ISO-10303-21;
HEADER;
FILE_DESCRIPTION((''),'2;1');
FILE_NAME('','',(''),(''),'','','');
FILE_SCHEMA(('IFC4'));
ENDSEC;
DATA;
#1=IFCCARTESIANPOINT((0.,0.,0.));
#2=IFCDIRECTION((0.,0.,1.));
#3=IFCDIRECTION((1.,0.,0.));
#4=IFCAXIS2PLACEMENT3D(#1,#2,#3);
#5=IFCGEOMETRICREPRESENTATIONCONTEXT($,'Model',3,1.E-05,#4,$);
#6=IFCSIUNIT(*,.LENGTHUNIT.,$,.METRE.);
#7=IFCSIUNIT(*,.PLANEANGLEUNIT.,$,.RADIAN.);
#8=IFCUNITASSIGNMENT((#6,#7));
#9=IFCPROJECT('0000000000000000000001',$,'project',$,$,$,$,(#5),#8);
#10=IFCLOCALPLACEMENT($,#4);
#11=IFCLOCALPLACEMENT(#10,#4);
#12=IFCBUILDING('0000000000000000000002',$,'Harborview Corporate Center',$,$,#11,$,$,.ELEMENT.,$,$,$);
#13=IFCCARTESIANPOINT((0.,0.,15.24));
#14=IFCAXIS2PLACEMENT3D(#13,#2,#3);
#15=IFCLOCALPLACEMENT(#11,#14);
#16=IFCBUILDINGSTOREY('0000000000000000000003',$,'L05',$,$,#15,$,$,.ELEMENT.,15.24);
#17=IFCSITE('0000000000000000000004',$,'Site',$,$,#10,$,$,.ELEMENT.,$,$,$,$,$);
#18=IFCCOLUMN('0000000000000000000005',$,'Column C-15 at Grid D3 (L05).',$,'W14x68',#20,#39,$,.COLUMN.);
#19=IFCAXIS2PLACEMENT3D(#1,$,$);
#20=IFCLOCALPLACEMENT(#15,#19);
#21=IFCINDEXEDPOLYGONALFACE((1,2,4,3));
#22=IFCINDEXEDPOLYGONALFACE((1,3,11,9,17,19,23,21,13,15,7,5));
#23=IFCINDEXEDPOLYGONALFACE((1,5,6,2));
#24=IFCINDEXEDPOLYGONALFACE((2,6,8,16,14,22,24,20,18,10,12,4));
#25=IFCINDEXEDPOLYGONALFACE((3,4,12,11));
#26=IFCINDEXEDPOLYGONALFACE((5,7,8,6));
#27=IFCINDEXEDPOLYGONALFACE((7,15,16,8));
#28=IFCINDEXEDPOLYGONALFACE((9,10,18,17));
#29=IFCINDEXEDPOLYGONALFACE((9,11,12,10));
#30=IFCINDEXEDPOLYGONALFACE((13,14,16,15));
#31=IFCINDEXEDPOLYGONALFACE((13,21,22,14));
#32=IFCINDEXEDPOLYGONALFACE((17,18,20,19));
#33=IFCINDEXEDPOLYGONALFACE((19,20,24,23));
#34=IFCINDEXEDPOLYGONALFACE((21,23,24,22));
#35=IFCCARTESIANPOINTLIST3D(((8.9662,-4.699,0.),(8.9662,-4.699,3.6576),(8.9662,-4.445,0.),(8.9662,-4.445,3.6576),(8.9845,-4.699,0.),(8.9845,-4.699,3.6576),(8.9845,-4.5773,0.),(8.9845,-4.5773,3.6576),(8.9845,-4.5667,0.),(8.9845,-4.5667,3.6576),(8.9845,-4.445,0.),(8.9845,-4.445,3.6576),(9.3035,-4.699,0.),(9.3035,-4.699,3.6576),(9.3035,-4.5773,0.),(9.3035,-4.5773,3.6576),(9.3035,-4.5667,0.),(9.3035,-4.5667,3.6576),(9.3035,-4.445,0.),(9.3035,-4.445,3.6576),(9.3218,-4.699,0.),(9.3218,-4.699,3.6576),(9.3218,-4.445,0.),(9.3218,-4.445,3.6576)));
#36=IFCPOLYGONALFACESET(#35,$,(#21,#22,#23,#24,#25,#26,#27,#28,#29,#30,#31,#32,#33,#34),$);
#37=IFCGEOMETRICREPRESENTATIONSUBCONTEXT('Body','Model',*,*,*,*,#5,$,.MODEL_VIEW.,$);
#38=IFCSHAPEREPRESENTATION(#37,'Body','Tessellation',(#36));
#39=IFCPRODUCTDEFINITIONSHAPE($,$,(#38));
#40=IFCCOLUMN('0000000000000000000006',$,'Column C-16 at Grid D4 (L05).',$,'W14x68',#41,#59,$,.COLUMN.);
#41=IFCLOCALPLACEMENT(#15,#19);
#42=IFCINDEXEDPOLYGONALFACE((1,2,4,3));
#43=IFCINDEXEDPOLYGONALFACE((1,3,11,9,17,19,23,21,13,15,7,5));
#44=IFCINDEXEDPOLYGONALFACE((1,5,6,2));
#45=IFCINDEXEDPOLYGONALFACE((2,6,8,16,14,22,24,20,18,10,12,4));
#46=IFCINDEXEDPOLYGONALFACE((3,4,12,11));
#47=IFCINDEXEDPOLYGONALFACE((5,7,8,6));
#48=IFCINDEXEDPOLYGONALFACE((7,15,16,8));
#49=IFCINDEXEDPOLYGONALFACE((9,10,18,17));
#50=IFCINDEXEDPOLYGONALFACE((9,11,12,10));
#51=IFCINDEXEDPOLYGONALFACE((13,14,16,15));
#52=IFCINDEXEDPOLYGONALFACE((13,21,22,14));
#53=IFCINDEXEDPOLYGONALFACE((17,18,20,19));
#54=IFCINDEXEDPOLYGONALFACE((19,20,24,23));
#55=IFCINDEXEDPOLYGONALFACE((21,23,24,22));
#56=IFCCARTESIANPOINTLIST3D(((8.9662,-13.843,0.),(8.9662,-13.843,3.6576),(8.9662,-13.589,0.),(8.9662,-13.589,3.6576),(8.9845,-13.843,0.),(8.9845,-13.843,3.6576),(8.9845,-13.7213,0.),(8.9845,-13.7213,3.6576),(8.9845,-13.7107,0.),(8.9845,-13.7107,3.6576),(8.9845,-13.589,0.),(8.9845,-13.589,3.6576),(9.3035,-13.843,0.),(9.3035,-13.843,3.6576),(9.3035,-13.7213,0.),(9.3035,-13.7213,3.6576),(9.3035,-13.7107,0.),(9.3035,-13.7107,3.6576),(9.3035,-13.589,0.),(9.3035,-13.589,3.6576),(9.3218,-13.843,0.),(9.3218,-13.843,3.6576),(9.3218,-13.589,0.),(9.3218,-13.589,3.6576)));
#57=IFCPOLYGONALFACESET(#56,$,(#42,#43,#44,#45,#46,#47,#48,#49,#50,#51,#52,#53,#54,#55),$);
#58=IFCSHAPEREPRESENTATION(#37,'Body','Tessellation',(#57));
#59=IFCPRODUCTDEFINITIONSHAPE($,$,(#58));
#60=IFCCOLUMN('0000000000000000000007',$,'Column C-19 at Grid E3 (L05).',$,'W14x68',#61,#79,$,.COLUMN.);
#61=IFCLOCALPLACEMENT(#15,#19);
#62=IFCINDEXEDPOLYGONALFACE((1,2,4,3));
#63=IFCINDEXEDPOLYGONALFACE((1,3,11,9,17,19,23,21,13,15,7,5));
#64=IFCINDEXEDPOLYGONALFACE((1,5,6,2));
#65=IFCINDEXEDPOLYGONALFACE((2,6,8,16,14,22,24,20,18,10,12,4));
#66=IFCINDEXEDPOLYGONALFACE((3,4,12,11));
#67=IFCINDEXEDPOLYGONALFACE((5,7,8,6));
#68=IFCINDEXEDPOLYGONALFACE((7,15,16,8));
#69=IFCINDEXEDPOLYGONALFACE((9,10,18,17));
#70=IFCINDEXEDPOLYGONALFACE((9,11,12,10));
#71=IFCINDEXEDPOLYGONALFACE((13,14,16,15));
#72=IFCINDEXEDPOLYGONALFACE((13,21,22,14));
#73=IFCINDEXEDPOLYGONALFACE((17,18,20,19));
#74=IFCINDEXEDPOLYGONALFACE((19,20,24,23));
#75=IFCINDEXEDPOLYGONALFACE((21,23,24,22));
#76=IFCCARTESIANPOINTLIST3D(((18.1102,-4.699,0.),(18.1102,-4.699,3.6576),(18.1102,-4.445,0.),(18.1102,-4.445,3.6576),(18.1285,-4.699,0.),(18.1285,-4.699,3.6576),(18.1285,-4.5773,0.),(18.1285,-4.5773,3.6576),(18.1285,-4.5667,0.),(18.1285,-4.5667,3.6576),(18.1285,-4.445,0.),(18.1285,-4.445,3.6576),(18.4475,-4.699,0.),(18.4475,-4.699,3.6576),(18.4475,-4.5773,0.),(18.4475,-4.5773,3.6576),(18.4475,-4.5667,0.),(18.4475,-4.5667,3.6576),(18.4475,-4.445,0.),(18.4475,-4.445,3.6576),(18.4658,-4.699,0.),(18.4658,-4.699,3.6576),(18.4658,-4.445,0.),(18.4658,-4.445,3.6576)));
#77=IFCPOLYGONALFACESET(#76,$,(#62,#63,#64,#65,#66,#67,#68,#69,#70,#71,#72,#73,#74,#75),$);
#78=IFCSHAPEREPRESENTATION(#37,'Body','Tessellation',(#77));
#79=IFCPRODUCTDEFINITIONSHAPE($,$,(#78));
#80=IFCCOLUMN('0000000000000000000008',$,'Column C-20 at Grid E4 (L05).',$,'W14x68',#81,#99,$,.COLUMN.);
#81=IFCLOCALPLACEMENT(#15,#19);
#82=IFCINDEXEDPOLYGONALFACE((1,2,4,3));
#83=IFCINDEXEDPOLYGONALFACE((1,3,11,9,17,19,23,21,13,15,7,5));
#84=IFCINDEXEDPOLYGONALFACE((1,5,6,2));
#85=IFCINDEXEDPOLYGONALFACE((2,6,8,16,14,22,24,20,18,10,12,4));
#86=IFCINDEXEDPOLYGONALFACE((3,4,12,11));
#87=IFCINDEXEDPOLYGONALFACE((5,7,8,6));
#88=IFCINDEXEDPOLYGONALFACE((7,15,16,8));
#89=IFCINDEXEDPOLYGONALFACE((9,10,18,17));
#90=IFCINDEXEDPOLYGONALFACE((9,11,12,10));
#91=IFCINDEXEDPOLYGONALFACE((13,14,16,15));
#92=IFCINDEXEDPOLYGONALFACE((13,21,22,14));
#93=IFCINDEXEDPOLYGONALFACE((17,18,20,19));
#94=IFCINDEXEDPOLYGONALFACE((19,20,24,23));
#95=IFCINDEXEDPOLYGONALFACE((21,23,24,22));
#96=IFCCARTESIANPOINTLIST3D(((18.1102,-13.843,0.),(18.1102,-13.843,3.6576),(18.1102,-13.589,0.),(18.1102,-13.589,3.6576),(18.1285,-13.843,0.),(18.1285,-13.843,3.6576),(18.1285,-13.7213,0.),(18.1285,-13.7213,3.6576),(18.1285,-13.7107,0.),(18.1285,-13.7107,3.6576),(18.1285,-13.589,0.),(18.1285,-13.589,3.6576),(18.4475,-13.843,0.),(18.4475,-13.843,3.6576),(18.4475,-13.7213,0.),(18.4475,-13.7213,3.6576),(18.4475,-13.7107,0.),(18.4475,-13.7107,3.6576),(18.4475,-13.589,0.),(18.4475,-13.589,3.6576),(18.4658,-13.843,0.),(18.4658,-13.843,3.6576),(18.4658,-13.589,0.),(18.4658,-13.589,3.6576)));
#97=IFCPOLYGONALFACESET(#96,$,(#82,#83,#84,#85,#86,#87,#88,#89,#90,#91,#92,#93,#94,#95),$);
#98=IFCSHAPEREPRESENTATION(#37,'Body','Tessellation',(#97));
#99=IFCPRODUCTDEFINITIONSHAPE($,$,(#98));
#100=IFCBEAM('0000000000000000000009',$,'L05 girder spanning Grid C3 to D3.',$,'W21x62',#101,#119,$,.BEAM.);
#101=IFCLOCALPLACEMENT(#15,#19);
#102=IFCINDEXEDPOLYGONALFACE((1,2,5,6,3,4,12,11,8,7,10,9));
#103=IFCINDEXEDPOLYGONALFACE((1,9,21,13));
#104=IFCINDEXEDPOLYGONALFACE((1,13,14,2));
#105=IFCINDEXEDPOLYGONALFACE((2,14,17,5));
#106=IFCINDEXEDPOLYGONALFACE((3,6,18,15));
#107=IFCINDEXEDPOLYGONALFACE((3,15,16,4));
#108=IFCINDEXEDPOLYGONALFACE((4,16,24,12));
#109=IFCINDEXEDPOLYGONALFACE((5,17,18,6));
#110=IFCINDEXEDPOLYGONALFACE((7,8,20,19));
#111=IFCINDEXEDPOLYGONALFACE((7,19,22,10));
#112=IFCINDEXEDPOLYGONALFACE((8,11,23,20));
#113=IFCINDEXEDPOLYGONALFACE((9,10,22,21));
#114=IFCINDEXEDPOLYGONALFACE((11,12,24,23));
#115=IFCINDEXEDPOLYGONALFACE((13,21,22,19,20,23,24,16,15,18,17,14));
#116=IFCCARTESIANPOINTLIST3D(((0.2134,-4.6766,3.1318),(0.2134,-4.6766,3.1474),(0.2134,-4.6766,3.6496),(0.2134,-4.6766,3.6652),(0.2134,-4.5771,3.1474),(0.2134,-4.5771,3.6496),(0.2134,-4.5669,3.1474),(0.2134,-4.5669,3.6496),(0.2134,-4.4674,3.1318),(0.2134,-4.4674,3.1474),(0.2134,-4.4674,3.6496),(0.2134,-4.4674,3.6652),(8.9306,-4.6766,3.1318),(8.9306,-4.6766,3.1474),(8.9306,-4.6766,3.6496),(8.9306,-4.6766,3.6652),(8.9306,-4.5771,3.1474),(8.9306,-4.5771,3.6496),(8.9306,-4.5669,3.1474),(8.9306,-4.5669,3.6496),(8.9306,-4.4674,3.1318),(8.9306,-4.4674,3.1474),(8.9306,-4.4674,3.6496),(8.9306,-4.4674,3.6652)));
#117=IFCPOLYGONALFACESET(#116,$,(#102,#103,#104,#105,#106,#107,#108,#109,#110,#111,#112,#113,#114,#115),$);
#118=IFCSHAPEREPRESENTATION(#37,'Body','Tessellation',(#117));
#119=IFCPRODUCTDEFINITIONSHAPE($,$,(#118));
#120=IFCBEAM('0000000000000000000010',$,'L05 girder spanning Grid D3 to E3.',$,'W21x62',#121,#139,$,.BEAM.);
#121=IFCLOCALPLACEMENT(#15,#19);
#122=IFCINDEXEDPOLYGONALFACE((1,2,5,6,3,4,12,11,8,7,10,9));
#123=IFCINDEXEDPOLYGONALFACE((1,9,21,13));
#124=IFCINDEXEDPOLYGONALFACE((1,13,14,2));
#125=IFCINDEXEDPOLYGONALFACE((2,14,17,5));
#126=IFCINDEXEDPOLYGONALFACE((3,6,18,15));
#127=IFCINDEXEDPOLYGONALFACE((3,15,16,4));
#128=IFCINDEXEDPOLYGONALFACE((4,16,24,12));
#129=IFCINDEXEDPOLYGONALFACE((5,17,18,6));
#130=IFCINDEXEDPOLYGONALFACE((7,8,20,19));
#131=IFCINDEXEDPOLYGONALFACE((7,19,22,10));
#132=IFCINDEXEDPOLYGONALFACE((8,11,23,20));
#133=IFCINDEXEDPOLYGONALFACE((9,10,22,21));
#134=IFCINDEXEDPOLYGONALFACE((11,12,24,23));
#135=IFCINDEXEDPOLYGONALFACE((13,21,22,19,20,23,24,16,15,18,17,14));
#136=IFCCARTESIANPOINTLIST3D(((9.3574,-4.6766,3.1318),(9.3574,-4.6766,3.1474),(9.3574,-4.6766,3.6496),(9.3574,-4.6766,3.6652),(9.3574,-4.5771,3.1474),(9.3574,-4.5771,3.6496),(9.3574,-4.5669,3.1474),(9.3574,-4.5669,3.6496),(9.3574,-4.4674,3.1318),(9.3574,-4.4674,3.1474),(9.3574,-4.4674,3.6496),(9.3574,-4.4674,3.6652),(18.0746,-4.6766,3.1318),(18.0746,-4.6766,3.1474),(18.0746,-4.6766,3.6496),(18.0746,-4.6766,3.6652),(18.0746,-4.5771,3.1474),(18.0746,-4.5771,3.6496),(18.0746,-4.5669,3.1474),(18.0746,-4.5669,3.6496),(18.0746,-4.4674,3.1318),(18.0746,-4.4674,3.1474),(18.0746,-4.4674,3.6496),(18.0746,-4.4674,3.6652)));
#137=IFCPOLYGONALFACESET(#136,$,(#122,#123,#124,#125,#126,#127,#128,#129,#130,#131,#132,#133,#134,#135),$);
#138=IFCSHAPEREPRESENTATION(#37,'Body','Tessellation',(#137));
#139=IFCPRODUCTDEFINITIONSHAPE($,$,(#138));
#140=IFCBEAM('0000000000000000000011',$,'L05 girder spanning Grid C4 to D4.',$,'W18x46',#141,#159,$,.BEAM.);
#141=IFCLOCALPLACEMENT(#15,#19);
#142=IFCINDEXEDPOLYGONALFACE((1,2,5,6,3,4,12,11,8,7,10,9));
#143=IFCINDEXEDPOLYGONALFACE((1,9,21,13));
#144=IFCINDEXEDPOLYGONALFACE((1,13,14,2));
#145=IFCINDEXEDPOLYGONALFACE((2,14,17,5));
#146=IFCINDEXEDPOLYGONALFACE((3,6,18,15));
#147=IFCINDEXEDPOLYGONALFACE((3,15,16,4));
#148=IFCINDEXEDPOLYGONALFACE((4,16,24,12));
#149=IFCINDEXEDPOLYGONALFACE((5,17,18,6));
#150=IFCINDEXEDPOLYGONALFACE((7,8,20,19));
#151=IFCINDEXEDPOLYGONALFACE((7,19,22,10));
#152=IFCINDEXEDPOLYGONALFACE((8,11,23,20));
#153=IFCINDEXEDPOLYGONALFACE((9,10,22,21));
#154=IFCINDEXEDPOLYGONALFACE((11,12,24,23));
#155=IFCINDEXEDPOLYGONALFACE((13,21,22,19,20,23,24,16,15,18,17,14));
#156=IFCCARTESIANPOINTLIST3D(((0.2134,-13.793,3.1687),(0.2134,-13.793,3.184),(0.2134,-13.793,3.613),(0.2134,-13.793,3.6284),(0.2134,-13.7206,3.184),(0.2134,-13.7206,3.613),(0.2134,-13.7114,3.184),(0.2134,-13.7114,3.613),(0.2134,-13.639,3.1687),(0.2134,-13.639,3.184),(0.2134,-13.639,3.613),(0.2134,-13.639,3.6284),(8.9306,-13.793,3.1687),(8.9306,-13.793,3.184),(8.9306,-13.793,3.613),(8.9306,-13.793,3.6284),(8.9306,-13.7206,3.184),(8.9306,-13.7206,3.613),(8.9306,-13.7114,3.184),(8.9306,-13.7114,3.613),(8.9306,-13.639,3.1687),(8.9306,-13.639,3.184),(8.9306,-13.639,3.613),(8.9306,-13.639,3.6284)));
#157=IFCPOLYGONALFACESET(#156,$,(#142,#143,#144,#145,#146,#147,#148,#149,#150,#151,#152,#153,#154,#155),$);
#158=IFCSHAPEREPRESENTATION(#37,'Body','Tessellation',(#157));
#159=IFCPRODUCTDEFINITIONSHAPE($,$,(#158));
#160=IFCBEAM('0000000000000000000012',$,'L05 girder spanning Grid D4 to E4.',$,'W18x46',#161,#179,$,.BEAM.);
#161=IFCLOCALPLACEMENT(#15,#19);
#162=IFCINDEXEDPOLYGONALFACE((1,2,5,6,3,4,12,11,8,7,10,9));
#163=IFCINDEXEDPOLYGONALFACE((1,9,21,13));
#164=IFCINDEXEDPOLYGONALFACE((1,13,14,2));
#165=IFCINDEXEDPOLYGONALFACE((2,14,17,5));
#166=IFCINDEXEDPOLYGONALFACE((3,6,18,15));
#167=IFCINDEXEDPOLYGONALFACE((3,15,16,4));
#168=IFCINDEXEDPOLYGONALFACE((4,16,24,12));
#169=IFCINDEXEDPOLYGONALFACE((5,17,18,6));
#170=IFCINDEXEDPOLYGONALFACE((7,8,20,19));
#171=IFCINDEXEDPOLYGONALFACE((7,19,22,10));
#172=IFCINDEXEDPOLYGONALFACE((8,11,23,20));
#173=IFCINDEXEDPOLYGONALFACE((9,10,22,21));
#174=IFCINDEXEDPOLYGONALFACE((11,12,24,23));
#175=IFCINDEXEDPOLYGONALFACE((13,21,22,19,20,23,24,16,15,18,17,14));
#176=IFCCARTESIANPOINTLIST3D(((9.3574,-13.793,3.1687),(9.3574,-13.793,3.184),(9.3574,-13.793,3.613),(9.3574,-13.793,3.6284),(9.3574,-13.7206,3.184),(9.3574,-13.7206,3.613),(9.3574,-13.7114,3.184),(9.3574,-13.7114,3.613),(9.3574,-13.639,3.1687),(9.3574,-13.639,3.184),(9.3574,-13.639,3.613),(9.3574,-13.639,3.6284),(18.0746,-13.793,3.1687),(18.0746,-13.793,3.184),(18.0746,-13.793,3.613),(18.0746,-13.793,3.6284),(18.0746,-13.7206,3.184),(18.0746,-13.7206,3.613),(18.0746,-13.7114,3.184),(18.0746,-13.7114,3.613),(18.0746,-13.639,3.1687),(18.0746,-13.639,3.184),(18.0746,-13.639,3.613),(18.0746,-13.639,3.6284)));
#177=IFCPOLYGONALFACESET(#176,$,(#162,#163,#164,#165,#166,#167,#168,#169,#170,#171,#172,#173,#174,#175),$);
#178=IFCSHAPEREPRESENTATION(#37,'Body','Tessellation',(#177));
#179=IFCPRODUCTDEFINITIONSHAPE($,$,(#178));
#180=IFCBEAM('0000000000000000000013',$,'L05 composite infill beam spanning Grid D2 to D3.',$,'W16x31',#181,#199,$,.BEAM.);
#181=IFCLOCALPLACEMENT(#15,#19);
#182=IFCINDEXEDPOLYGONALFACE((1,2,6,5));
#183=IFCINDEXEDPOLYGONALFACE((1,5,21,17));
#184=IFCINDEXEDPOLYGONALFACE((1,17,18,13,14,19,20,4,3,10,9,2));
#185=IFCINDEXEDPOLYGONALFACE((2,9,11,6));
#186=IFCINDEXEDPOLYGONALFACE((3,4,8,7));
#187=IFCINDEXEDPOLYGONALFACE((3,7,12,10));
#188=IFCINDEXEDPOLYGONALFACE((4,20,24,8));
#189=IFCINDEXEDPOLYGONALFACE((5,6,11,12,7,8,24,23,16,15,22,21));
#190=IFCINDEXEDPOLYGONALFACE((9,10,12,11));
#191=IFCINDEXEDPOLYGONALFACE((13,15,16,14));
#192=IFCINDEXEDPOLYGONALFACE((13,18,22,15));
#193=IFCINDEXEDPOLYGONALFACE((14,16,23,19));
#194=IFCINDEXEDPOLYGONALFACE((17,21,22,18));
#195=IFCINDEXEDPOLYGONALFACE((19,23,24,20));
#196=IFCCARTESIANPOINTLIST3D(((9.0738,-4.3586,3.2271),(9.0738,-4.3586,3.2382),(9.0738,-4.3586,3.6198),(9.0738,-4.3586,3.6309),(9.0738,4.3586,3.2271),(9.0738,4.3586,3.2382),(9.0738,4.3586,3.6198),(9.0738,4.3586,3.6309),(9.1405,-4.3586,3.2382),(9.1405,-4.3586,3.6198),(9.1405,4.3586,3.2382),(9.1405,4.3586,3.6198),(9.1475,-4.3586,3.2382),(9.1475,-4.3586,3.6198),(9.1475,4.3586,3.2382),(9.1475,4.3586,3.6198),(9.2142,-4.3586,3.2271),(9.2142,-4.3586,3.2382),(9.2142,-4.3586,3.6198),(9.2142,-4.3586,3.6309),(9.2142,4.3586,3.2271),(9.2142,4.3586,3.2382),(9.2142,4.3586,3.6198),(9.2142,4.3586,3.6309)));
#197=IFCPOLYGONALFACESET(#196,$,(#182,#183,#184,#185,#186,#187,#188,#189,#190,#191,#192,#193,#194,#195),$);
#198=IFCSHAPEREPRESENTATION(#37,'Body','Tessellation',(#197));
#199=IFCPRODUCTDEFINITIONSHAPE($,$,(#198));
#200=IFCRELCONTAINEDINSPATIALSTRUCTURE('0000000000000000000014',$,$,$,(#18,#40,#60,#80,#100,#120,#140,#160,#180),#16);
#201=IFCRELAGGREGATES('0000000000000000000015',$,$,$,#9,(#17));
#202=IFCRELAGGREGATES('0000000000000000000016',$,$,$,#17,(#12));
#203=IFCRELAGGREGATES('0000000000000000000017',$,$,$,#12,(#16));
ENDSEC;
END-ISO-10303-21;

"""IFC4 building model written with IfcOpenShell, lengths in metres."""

from ifc_helpers import new_model, si_unit, frame, origin_with_axes, place, context, subcontext, project, spatial, i_section, extrude, element, save


model = new_model("IFC4")

# Units and contexts
model_context = context("Model", 3, precision=1e-05, world=origin_with_axes())
body_context = subcontext(model_context, "Body", "Model", "MODEL_VIEW")
ifc_project = project(units=[si_unit("LENGTHUNIT", "METRE"), si_unit("PLANEANGLEUNIT", "RADIAN")], contexts=[model_context])

# Site, building, storey
site_placement = place(None, origin_with_axes())
site = spatial("IfcSite", under=ifc_project, at=site_placement, Name="Site", CompositionType="ELEMENT")
building_placement = place(site_placement, origin_with_axes())
building = spatial("IfcBuilding", under=site, at=building_placement, Name="Harborview Corporate Center", CompositionType="ELEMENT")
storey_placement = place(building_placement, frame((0.0, 0.0, 15.24), z_axis=(0.0, 0.0, 1.0), x_axis=(1.0, 0.0, 0.0)))
storey = spatial("IfcBuildingStorey", under=building, at=storey_placement, Name="L05", CompositionType="ELEMENT", Elevation=15.24)

# Columns
for number, where, z_axis, x_axis, name in (
    (1, (9.144, -4.572, 0.0), (0.0, 0.0, 1.0), (0.0, 1.0, 0.0), "Column C-15 at Grid D3 (L05)."),
    (2, (9.144, -13.716, 0.0), (0.0, 0.0, 1.0), (0.0, 1.0, 0.0), "Column C-16 at Grid D4 (L05)."),
    (3, (18.288, -4.572, 0.0), (0.0, 0.0, 1.0), (0.0, 1.0, 0.0), "Column C-19 at Grid E3 (L05)."),
    (4, (18.288, -13.716, 0.0), (0.0, 0.0, 1.0), (0.0, 1.0, 0.0), "Column C-20 at Grid E4 (L05)."),
):
    element("IfcColumn", number, at=place(storey_placement, frame(where, z_axis=z_axis, x_axis=x_axis)), inside=storey, Name=name, ObjectType="W14x68", PredefinedType="COLUMN", context=body_context, shape_type="SweptSolid", body=[
        extrude(i_section(OverallWidth=0.254, OverallDepth=0.3556, WebThickness=0.0105, FlangeThickness=0.0183), origin_with_axes(), (0.0, 0.0, 1.0), 3.6576),
    ])

# Beams
beam_1_placement = place(storey_placement, frame((0.2134, -4.572, 3.3985), z_axis=(1.0, 0.0, 0.0), x_axis=(0.0, 1.0, 0.0)))
element("IfcBeam", 5, at=beam_1_placement, inside=storey, Name="L05 girder spanning Grid C3 to D3.", ObjectType="W21x62", PredefinedType="BEAM", context=body_context, shape_type="SweptSolid", body=[
    extrude(i_section(OverallWidth=0.2093, OverallDepth=0.5334, WebThickness=0.0102, FlangeThickness=0.0156), origin_with_axes(), (0.0, 0.0, 1.0), 8.7173),
])
beam_2_placement = place(storey_placement, frame((9.3574, -4.572, 3.3985), z_axis=(1.0, 0.0, 0.0), x_axis=(0.0, 1.0, 0.0)))
element("IfcBeam", 6, at=beam_2_placement, inside=storey, Name="L05 girder spanning Grid D3 to E3.", ObjectType="W21x62", PredefinedType="BEAM", context=body_context, shape_type="SweptSolid", body=[
    extrude(i_section(OverallWidth=0.2093, OverallDepth=0.5334, WebThickness=0.0102, FlangeThickness=0.0156), origin_with_axes(), (0.0, 0.0, 1.0), 8.7173),
])
beam_3_placement = place(storey_placement, frame((0.2134, -13.716, 3.3985), z_axis=(1.0, 0.0, 0.0), x_axis=(0.0, 1.0, 0.0)))
element("IfcBeam", 7, at=beam_3_placement, inside=storey, Name="L05 girder spanning Grid C4 to D4.", ObjectType="W18x46", PredefinedType="BEAM", context=body_context, shape_type="SweptSolid", body=[
    extrude(i_section(OverallWidth=0.1539, OverallDepth=0.4597, WebThickness=0.0091, FlangeThickness=0.0154), origin_with_axes(), (0.0, 0.0, 1.0), 8.7173),
])
beam_4_placement = place(storey_placement, frame((9.3574, -13.716, 3.3985), z_axis=(1.0, 0.0, 0.0), x_axis=(0.0, 1.0, 0.0)))
element("IfcBeam", 8, at=beam_4_placement, inside=storey, Name="L05 girder spanning Grid D4 to E4.", ObjectType="W18x46", PredefinedType="BEAM", context=body_context, shape_type="SweptSolid", body=[
    extrude(i_section(OverallWidth=0.1539, OverallDepth=0.4597, WebThickness=0.0091, FlangeThickness=0.0154), origin_with_axes(), (0.0, 0.0, 1.0), 8.7173),
])
beam_5_placement = place(storey_placement, frame((9.144, -4.3586, 3.429), z_axis=(0.0, 1.0, 0.0), x_axis=(-1.0, 0.0, 0.0)))
element("IfcBeam", 9, at=beam_5_placement, inside=storey, Name="L05 composite infill beam spanning Grid D2 to D3.", ObjectType="W16x31", PredefinedType="BEAM", context=body_context, shape_type="SweptSolid", body=[
    extrude(i_section(OverallWidth=0.1405, OverallDepth=0.4039, WebThickness=0.007, FlangeThickness=0.0112), origin_with_axes(), (0.0, 0.0, 1.0), 8.7173),
])

save(model, "model.ifc")
